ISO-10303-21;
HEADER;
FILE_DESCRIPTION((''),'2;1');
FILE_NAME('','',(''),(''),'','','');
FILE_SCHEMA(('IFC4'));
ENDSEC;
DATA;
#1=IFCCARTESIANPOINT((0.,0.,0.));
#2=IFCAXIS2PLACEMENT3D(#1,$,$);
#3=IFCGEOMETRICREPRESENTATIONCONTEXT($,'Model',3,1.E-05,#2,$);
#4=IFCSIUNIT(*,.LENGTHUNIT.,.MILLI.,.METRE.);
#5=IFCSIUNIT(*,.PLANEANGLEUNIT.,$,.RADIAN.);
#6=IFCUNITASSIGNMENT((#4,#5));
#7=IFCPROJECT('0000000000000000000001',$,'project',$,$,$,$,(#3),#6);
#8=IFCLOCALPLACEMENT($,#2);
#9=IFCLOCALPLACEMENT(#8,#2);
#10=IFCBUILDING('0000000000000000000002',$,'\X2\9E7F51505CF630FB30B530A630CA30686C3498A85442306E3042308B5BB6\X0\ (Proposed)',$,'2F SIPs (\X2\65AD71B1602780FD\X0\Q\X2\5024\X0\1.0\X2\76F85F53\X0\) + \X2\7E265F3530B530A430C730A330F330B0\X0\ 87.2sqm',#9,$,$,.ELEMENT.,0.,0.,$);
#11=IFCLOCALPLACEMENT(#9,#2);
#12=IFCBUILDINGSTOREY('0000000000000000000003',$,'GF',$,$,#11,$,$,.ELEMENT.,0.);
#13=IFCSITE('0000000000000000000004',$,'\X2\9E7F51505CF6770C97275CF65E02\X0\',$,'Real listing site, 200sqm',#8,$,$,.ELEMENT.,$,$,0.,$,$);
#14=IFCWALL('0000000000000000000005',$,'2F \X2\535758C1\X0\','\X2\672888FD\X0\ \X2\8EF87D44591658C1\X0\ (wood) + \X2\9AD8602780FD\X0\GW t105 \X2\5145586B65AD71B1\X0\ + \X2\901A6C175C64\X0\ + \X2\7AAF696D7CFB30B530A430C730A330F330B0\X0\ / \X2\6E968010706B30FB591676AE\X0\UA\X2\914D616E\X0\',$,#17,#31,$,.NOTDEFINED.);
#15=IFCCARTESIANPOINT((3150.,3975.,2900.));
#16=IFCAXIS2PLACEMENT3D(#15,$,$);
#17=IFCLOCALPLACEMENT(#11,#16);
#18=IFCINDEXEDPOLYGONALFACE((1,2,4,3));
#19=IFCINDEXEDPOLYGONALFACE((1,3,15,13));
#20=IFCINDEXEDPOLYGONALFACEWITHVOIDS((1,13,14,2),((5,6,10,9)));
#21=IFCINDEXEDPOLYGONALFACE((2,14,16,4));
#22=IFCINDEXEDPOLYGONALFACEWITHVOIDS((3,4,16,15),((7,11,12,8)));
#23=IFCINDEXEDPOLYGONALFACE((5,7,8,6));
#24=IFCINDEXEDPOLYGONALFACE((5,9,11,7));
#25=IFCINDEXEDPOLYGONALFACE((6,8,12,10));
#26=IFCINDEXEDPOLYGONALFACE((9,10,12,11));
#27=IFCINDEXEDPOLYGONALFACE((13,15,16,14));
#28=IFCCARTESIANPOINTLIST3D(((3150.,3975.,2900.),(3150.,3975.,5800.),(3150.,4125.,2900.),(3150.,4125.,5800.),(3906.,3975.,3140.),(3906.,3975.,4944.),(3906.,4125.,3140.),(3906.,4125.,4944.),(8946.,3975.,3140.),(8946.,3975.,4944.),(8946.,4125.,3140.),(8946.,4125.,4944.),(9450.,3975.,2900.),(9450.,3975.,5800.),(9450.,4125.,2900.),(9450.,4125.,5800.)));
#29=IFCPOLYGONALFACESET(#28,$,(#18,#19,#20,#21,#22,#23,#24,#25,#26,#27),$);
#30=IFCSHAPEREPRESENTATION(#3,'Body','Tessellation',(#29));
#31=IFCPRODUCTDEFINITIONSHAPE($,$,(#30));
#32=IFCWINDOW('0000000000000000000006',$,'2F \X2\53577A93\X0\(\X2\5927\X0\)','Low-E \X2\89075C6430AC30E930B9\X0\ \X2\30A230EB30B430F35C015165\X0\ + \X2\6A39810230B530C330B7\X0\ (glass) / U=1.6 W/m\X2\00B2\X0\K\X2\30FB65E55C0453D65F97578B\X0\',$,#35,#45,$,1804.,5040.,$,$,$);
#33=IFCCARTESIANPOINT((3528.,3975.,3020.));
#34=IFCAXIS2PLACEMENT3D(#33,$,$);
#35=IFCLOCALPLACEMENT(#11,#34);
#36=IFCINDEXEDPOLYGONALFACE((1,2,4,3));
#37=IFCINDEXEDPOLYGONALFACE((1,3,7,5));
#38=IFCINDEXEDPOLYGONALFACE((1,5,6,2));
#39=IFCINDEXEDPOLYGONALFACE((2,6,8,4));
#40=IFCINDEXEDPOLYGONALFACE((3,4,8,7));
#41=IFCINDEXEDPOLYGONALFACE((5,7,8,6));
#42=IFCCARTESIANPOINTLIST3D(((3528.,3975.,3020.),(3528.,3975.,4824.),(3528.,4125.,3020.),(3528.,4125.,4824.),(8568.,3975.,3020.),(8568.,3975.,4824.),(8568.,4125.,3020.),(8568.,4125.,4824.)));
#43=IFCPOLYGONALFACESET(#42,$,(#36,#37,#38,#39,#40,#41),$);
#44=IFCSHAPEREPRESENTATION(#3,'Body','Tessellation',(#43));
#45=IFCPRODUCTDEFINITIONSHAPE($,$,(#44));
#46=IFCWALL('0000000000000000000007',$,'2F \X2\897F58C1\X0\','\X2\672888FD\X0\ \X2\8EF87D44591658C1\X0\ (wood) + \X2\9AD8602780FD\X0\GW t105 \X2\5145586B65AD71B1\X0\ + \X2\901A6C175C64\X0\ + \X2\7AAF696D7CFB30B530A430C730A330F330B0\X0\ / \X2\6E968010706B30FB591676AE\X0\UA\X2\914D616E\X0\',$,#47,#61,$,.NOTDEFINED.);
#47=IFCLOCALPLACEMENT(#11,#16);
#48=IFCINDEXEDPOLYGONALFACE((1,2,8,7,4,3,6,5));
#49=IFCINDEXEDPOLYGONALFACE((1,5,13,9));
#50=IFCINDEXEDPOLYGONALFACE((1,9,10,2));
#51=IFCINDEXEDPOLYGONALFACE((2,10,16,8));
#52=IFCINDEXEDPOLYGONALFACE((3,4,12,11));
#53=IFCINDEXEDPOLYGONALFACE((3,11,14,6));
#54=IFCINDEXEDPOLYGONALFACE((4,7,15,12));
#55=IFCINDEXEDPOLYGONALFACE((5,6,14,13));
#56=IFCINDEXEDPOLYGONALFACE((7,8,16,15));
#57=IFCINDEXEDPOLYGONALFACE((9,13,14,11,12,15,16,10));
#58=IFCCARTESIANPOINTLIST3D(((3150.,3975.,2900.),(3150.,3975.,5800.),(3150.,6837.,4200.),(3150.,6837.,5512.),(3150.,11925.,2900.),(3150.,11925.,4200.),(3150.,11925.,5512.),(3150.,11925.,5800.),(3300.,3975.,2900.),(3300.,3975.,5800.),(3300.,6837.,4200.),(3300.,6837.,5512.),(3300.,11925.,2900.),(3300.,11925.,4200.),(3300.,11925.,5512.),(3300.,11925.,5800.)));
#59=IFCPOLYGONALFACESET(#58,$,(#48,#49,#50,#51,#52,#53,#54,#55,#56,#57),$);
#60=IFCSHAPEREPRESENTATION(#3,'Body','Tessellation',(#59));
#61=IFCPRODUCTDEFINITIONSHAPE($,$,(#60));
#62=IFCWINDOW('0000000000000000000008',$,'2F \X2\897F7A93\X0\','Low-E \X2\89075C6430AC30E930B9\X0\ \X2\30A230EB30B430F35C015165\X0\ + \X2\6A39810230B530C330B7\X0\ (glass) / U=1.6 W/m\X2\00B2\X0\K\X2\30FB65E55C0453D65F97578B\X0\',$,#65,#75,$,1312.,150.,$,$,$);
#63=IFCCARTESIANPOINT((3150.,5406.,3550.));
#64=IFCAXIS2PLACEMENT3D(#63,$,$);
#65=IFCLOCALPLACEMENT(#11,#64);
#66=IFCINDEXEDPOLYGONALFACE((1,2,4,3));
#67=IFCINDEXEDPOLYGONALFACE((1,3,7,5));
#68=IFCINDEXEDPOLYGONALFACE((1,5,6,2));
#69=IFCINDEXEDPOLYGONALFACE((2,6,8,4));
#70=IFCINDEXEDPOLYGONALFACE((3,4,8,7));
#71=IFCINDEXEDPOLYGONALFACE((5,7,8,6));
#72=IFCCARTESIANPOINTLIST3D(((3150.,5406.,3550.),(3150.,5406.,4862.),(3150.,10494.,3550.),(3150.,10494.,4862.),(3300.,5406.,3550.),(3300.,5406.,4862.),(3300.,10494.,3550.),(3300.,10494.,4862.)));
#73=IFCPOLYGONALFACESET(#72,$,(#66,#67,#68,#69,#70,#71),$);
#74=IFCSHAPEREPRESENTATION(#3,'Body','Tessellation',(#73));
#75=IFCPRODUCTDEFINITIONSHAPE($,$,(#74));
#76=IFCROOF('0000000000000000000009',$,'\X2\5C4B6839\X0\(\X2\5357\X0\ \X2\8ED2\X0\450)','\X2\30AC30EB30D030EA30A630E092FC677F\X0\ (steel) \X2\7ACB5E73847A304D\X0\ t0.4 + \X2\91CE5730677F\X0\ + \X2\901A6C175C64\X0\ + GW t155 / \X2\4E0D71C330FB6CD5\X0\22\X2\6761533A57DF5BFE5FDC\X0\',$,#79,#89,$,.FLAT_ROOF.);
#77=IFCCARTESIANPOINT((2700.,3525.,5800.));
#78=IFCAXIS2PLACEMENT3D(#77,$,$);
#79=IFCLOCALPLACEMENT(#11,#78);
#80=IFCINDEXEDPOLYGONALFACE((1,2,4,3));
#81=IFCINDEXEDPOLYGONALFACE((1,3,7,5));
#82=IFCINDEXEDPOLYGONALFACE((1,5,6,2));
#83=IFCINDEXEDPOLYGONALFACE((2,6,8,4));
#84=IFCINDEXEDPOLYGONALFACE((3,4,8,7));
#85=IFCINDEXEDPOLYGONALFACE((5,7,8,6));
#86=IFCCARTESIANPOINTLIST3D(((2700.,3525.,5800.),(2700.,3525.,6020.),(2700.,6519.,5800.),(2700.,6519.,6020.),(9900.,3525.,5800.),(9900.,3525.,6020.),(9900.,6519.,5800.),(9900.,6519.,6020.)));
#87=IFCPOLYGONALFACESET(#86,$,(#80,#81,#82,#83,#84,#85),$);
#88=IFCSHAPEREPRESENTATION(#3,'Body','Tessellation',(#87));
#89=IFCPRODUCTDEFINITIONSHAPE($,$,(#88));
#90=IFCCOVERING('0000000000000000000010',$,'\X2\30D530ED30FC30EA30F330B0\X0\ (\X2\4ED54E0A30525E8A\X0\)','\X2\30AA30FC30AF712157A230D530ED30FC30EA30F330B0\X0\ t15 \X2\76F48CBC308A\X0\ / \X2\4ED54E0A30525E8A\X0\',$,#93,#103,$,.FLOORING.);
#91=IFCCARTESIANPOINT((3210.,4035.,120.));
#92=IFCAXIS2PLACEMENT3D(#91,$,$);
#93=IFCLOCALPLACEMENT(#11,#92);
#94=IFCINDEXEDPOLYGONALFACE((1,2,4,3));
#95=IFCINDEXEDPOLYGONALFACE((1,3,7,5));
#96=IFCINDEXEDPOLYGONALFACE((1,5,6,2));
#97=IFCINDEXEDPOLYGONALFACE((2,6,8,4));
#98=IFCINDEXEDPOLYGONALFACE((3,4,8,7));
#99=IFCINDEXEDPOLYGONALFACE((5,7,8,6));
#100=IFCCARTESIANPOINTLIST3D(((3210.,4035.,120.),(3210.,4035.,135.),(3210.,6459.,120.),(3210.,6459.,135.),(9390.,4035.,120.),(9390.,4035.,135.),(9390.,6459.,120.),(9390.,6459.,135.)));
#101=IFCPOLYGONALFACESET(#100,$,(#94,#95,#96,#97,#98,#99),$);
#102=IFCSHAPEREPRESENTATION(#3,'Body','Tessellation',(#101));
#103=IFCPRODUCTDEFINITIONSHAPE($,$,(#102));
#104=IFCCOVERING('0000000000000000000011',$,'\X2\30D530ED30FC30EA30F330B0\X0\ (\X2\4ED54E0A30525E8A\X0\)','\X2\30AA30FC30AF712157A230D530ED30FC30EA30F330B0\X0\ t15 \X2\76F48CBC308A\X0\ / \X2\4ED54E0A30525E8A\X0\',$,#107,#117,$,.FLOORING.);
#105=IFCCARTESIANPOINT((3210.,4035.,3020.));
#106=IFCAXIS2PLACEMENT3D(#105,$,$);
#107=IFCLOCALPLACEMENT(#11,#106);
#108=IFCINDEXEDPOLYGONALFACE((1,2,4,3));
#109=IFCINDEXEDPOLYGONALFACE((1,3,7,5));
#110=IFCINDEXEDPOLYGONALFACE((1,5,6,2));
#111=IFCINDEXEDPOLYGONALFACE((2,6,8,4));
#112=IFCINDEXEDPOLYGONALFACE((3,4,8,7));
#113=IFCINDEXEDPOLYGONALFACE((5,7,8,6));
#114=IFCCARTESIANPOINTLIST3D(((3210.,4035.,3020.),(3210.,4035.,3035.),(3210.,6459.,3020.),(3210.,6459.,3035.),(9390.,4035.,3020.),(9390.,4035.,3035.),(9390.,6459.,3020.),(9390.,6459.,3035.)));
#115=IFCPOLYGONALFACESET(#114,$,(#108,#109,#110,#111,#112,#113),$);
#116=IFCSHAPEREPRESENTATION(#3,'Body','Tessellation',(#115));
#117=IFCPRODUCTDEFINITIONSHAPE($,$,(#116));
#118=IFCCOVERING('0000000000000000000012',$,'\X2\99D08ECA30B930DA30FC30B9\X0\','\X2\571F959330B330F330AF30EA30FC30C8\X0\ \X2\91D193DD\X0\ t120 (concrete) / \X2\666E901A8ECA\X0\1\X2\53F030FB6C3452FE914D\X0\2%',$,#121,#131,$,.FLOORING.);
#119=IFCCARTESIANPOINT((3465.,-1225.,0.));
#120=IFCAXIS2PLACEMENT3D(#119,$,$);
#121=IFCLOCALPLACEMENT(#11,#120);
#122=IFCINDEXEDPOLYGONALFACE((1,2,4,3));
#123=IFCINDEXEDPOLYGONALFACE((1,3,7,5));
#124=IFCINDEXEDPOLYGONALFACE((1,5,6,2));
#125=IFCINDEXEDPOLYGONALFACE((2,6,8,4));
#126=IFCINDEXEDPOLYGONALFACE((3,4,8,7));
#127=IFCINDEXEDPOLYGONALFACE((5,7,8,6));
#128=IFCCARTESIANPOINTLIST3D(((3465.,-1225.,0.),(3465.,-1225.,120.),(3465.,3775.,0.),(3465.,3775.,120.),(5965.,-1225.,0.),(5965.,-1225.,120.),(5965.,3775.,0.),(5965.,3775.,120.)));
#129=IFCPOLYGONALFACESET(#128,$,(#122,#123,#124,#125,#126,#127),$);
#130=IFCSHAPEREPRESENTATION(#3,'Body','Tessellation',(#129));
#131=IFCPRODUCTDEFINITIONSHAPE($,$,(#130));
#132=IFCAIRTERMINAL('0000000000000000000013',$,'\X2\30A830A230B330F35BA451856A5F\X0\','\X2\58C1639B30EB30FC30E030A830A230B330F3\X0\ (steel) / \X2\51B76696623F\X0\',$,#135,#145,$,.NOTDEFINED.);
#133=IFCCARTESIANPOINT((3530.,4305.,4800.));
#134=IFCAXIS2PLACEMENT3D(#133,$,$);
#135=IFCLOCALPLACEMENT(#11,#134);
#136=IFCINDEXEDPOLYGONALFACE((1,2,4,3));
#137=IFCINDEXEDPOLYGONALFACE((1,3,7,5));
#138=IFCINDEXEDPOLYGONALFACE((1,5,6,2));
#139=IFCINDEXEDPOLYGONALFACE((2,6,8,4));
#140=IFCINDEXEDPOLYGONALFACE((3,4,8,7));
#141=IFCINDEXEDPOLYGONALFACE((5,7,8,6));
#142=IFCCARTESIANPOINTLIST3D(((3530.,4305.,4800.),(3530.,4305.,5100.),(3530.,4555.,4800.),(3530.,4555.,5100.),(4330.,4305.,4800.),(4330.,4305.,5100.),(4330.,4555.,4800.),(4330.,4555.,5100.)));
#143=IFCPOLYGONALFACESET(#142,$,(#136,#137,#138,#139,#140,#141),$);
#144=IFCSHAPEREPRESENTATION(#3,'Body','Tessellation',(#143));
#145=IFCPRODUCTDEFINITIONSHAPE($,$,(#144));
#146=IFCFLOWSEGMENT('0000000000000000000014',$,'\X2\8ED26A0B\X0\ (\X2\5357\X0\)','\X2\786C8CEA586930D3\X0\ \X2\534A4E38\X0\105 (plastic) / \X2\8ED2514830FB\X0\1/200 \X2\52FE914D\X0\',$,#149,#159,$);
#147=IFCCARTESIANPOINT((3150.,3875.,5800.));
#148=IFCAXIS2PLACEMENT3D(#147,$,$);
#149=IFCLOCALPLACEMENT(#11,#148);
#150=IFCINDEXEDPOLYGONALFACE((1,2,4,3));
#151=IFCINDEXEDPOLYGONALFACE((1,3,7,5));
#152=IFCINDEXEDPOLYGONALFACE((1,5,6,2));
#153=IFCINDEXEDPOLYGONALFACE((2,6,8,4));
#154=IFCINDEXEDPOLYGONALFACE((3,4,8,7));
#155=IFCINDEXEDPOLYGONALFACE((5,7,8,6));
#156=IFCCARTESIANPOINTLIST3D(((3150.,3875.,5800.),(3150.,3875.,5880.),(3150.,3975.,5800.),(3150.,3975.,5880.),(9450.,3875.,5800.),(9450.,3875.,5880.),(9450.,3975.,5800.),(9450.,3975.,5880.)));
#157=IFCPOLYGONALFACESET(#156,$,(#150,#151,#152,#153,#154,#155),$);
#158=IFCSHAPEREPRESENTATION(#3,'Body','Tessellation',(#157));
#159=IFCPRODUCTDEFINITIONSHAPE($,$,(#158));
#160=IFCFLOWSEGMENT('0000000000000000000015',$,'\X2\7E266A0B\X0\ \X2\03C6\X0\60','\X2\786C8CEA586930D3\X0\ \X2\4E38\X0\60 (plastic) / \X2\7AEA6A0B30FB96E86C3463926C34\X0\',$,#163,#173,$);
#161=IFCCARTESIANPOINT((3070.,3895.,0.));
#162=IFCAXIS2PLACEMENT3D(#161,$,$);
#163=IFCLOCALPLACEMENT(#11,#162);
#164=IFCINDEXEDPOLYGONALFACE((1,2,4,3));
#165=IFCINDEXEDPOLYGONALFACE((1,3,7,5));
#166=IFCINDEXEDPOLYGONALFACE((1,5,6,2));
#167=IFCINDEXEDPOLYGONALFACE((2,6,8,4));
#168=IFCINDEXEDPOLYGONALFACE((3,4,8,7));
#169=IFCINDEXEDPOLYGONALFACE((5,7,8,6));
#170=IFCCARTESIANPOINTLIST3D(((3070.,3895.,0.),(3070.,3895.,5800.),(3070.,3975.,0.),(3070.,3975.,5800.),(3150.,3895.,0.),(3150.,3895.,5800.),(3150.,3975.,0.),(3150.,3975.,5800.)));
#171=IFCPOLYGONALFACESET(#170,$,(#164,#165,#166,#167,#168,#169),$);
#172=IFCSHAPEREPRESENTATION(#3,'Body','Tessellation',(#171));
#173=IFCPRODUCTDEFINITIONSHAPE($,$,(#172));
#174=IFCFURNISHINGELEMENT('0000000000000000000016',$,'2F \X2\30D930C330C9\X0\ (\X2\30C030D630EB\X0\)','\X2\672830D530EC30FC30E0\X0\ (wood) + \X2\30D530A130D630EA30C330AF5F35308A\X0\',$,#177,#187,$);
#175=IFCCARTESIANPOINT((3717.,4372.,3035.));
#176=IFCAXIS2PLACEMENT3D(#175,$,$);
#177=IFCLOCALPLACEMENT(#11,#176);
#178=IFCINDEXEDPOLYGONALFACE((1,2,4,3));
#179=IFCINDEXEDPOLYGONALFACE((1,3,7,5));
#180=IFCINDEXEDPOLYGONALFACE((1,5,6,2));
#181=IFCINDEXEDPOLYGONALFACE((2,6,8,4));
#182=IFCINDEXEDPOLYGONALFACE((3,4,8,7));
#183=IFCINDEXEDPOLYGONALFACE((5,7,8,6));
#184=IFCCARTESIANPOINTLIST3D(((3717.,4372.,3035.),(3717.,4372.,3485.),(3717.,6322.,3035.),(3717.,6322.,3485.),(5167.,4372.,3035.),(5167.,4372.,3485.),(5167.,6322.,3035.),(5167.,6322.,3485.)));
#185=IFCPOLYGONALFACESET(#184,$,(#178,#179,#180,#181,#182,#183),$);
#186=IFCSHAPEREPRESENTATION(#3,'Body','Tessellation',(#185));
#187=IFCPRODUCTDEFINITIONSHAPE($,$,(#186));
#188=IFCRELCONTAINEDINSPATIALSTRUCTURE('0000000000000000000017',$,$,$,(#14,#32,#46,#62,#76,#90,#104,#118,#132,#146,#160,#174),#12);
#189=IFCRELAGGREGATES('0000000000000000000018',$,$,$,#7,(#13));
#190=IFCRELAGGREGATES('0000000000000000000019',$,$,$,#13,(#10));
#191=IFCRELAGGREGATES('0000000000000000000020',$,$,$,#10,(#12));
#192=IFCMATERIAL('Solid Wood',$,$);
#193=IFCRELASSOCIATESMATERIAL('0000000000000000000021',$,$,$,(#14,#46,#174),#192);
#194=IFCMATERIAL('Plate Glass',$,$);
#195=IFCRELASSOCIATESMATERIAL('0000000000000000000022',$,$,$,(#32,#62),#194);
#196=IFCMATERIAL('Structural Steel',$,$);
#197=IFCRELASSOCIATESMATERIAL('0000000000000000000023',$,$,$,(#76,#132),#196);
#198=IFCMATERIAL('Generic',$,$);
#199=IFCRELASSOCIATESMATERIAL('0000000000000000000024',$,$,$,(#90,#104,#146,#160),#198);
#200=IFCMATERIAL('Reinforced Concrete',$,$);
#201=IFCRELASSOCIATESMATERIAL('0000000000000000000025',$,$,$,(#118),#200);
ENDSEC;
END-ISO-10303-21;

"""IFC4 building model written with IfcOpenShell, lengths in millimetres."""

from ifc_helpers import new_model, si_unit, frame, frame_2d, origin, place, context, project, spatial, rectangle, extrude, material, element, fill, save


model = new_model("IFC4")

# Units and contexts
model_context = context("Model", 3, precision=1e-05, world=origin())
ifc_project = project(units=[si_unit("LENGTHUNIT", "METRE", prefix="MILLI"), si_unit("PLANEANGLEUNIT", "RADIAN")], contexts=[model_context])

# Site, building, storey
site_placement = place(None, origin())
site = spatial("IfcSite", under=ifc_project, at=site_placement, Name="鹿児島県霧島市", ObjectType="Real listing site, 200sqm", CompositionType="ELEMENT", RefElevation=0.0)
building_placement = place(site_placement, origin())
building = spatial("IfcBuilding", under=site, at=building_placement, Name="鹿児島・サウナと水風呂のある家 (Proposed)", ObjectType="2F SIPs (断熱性能Q値1.0相当) + 縦張サイディング 87.2sqm", CompositionType="ELEMENT", ElevationOfRefHeight=0.0, ElevationOfTerrain=0.0)
storey_placement = place(building_placement, origin())
storey = spatial("IfcBuildingStorey", under=building, at=storey_placement, Name="GF", CompositionType="ELEMENT", Elevation=0.0)

# Shared definitions
ifc_material_1 = material(Name="Solid Wood")

# Shared definitions
ifc_material_2 = material(Name="Reinforced Concrete")

# Shared definitions
ifc_material_3 = material(Name="Plate Glass")

# Walls, openings, windows
wall_1_placement = place(storey_placement, frame((3150.0, 3975.0, 2900.0)))
wall_1 = element("IfcWall", 1, at=wall_1_placement, inside=storey, material=ifc_material_1, Name="2F 南壁", Description="木製 軸組外壁 (wood) + 高性能GW t105 充填断熱 + 通気層 + 窯業系サイディング / 準耐火・外皮UA配慮", PredefinedType="NOTDEFINED", context=model_context, shape_type="SweptSolid", body=[
    extrude(rectangle(XDim=6300.0, YDim=150.0, at=frame_2d((3150.0, 75.0))), frame((3150.0, 3975.0, 2900.0)), (0.0, 0.0, 1.0), 2900.0),
])
opening_1_placement = place(storey_placement, frame((3528.0, 3975.0, 3020.0)))
opening_1 = element("IfcOpeningElement", 2, at=opening_1_placement, cuts=wall_1, PredefinedType="NOTDEFINED", context=model_context, shape_type="SweptSolid", body=[
    extrude(rectangle(XDim=5040.0, YDim=150.0, at=frame_2d((2520.0, 75.0))), frame((3528.0, 3975.0, 3020.0)), (0.0, 0.0, 1.0), 1804.0),
])
window_1_placement = place(storey_placement, frame((3528.0, 3975.0, 3020.0)))
window_1 = element("IfcWindow", 3, at=window_1_placement, inside=storey, material=ifc_material_3, Name="2F 南窓(大)", Description="Low-E 複層ガラス アルゴン封入 + 樹脂サッシ (glass) / U=1.6 W/m²K・日射取得型", OverallHeight=1804.0, OverallWidth=5040.0, context=model_context, shape_type="SweptSolid", body=[
    extrude(rectangle(XDim=5040.0, YDim=150.0, at=frame_2d((2520.0, 75.0))), frame((3528.0, 3975.0, 3020.0)), (0.0, 0.0, 1.0), 1804.0),
])
fill(opening_1, window_1)
wall_2_placement = place(storey_placement, frame((3150.0, 3975.0, 2900.0)))
wall_2 = element("IfcWall", 4, at=wall_2_placement, inside=storey, material=ifc_material_1, Name="2F 西壁", Description="木製 軸組外壁 (wood) + 高性能GW t105 充填断熱 + 通気層 + 窯業系サイディング / 準耐火・外皮UA配慮", PredefinedType="NOTDEFINED", context=model_context, shape_type="SweptSolid", body=[
    extrude(rectangle(XDim=150.0, YDim=7950.0, at=frame_2d((75.0, 3975.0))), frame((3150.0, 3975.0, 2900.0)), (0.0, 0.0, 1.0), 2900.0),
])
opening_2_placement = place(storey_placement, frame((3150.0, 5406.0, 3550.0)))
opening_2 = element("IfcOpeningElement", 5, at=opening_2_placement, cuts=wall_2, PredefinedType="NOTDEFINED", context=model_context, shape_type="SweptSolid", body=[
    extrude(rectangle(XDim=150.0, YDim=5088.0, at=frame_2d((75.0, 2544.0))), frame((3150.0, 5406.0, 3550.0)), (0.0, 0.0, 1.0), 1312.0),
])
window_2_placement = place(storey_placement, frame((3150.0, 5406.0, 3550.0)))
window_2 = element("IfcWindow", 6, at=window_2_placement, inside=storey, material=ifc_material_3, Name="2F 西窓", Description="Low-E 複層ガラス アルゴン封入 + 樹脂サッシ (glass) / U=1.6 W/m²K・日射取得型", OverallHeight=1312.0, OverallWidth=150.0, context=model_context, shape_type="SweptSolid", body=[
    extrude(rectangle(XDim=150.0, YDim=5088.0, at=frame_2d((75.0, 2544.0))), frame((3150.0, 5406.0, 3550.0)), (0.0, 0.0, 1.0), 1312.0),
])
fill(opening_2, window_2)

# Roof
ifc_material_4 = material(Name="Structural Steel")
for number, where, name in (
    (7, (2700.0, 3525.0, 5800.0), "屋根(南 軒450)"),
):
    element("IfcRoof", number, at=place(storey_placement, frame(where)), inside=storey, material=ifc_material_4, Name=name, Description="ガルバリウム鋼板 (steel) 立平葺き t0.4 + 野地板 + 通気層 + GW t155 / 不燃・法22条区域対応", PredefinedType="FLAT_ROOF", context=model_context, shape_type="SweptSolid", body=[
        extrude(rectangle(XDim=7200.0, YDim=2994.0, at=frame_2d((3600.0, 1497.0))), frame((2700.0, 3525.0, 5800.0)), (0.0, 0.0, 1.0), 220.0),
    ])

# Coverings
ifc_material_5 = material(Name="Generic")
covering_1_placement = place(storey_placement, frame((3210.0, 4035.0, 120.0)))
element("IfcCovering", 8, at=covering_1_placement, inside=storey, material=ifc_material_5, Name="フローリング (仕上げ床)", Description="オーク無垢フローリング t15 直貼り / 仕上げ床", PredefinedType="FLOORING", context=model_context, shape_type="SweptSolid", body=[
    extrude(rectangle(XDim=6180.0, YDim=2424.0, at=frame_2d((3090.0, 1212.0))), frame((3210.0, 4035.0, 120.0)), (0.0, 0.0, 1.0), 15.0),
])
covering_2_placement = place(storey_placement, frame((3210.0, 4035.0, 3020.0)))
element("IfcCovering", 9, at=covering_2_placement, inside=storey, material=ifc_material_5, Name="フローリング (仕上げ床)", Description="オーク無垢フローリング t15 直貼り / 仕上げ床", PredefinedType="FLOORING", context=model_context, shape_type="SweptSolid", body=[
    extrude(rectangle(XDim=6180.0, YDim=2424.0, at=frame_2d((3090.0, 1212.0))), frame((3210.0, 4035.0, 3020.0)), (0.0, 0.0, 1.0), 15.0),
])
covering_3_placement = place(storey_placement, frame((3465.0, -1225.0, 0.0)))
element("IfcCovering", 10, at=covering_3_placement, inside=storey, material=ifc_material_2, Name="駐車スペース", Description="土間コンクリート 金鏝 t120 (concrete) / 普通車1台・水勾配2%", PredefinedType="FLOORING", context=model_context, shape_type="SweptSolid", body=[
    extrude(rectangle(XDim=2500.0, YDim=5000.0, at=frame_2d((1250.0, 2500.0))), frame((3465.0, -1225.0, 0.0)), (0.0, 0.0, 1.0), 120.0),
])

# Air terminal
air_terminal_placement = place(storey_placement, frame((3530.0, 4305.0, 4800.0)))
element("IfcAirTerminal", 11, at=air_terminal_placement, inside=storey, material=ifc_material_4, Name="エアコン室内機", Description="壁掛ルームエアコン (steel) / 冷暖房", PredefinedType="NOTDEFINED", context=model_context, shape_type="SweptSolid", body=[
    extrude(rectangle(XDim=800.0, YDim=250.0, at=frame_2d((400.0, 125.0))), frame((3530.0, 4305.0, 4800.0)), (0.0, 0.0, 1.0), 300.0),
])

# Flow segments
flow_segment_1_placement = place(storey_placement, frame((3150.0, 3875.0, 5800.0)))
element("IfcFlowSegment", 12, at=flow_segment_1_placement, inside=storey, material=ifc_material_5, Name="軒樋 (南)", Description="硬質塩ビ 半丸105 (plastic) / 軒先・1/200 勾配", context=model_context, shape_type="SweptSolid", body=[
    extrude(rectangle(XDim=6300.0, YDim=100.0, at=frame_2d((3150.0, 50.0))), frame((3150.0, 3875.0, 5800.0)), (0.0, 0.0, 1.0), 80.0),
])
flow_segment_2_placement = place(storey_placement, frame((3070.0, 3895.0, 0.0)))
element("IfcFlowSegment", 13, at=flow_segment_2_placement, inside=storey, material=ifc_material_5, Name="縦樋 φ60", Description="硬質塩ビ 丸60 (plastic) / 竪樋・雨水排水", context=model_context, shape_type="SweptSolid", body=[
    extrude(rectangle(XDim=80.0, YDim=80.0, at=frame_2d((40.0, 40.0))), frame((3070.0, 3895.0, 0.0)), (0.0, 0.0, 1.0), 5800.0),
])

# Furnishing element
furnishing_placement = place(storey_placement, frame((3717.0, 4372.0, 3035.0)))
element("IfcFurnishingElement", 14, at=furnishing_placement, inside=storey, material=ifc_material_1, Name="2F ベッド (ダブル)", Description="木フレーム (wood) + ファブリック張り", context=model_context, shape_type="SweptSolid", body=[
    extrude(rectangle(XDim=1450.0, YDim=1950.0, at=frame_2d((725.0, 975.0))), frame((3717.0, 4372.0, 3035.0)), (0.0, 0.0, 1.0), 450.0),
])

save(model, "model.ifc")
